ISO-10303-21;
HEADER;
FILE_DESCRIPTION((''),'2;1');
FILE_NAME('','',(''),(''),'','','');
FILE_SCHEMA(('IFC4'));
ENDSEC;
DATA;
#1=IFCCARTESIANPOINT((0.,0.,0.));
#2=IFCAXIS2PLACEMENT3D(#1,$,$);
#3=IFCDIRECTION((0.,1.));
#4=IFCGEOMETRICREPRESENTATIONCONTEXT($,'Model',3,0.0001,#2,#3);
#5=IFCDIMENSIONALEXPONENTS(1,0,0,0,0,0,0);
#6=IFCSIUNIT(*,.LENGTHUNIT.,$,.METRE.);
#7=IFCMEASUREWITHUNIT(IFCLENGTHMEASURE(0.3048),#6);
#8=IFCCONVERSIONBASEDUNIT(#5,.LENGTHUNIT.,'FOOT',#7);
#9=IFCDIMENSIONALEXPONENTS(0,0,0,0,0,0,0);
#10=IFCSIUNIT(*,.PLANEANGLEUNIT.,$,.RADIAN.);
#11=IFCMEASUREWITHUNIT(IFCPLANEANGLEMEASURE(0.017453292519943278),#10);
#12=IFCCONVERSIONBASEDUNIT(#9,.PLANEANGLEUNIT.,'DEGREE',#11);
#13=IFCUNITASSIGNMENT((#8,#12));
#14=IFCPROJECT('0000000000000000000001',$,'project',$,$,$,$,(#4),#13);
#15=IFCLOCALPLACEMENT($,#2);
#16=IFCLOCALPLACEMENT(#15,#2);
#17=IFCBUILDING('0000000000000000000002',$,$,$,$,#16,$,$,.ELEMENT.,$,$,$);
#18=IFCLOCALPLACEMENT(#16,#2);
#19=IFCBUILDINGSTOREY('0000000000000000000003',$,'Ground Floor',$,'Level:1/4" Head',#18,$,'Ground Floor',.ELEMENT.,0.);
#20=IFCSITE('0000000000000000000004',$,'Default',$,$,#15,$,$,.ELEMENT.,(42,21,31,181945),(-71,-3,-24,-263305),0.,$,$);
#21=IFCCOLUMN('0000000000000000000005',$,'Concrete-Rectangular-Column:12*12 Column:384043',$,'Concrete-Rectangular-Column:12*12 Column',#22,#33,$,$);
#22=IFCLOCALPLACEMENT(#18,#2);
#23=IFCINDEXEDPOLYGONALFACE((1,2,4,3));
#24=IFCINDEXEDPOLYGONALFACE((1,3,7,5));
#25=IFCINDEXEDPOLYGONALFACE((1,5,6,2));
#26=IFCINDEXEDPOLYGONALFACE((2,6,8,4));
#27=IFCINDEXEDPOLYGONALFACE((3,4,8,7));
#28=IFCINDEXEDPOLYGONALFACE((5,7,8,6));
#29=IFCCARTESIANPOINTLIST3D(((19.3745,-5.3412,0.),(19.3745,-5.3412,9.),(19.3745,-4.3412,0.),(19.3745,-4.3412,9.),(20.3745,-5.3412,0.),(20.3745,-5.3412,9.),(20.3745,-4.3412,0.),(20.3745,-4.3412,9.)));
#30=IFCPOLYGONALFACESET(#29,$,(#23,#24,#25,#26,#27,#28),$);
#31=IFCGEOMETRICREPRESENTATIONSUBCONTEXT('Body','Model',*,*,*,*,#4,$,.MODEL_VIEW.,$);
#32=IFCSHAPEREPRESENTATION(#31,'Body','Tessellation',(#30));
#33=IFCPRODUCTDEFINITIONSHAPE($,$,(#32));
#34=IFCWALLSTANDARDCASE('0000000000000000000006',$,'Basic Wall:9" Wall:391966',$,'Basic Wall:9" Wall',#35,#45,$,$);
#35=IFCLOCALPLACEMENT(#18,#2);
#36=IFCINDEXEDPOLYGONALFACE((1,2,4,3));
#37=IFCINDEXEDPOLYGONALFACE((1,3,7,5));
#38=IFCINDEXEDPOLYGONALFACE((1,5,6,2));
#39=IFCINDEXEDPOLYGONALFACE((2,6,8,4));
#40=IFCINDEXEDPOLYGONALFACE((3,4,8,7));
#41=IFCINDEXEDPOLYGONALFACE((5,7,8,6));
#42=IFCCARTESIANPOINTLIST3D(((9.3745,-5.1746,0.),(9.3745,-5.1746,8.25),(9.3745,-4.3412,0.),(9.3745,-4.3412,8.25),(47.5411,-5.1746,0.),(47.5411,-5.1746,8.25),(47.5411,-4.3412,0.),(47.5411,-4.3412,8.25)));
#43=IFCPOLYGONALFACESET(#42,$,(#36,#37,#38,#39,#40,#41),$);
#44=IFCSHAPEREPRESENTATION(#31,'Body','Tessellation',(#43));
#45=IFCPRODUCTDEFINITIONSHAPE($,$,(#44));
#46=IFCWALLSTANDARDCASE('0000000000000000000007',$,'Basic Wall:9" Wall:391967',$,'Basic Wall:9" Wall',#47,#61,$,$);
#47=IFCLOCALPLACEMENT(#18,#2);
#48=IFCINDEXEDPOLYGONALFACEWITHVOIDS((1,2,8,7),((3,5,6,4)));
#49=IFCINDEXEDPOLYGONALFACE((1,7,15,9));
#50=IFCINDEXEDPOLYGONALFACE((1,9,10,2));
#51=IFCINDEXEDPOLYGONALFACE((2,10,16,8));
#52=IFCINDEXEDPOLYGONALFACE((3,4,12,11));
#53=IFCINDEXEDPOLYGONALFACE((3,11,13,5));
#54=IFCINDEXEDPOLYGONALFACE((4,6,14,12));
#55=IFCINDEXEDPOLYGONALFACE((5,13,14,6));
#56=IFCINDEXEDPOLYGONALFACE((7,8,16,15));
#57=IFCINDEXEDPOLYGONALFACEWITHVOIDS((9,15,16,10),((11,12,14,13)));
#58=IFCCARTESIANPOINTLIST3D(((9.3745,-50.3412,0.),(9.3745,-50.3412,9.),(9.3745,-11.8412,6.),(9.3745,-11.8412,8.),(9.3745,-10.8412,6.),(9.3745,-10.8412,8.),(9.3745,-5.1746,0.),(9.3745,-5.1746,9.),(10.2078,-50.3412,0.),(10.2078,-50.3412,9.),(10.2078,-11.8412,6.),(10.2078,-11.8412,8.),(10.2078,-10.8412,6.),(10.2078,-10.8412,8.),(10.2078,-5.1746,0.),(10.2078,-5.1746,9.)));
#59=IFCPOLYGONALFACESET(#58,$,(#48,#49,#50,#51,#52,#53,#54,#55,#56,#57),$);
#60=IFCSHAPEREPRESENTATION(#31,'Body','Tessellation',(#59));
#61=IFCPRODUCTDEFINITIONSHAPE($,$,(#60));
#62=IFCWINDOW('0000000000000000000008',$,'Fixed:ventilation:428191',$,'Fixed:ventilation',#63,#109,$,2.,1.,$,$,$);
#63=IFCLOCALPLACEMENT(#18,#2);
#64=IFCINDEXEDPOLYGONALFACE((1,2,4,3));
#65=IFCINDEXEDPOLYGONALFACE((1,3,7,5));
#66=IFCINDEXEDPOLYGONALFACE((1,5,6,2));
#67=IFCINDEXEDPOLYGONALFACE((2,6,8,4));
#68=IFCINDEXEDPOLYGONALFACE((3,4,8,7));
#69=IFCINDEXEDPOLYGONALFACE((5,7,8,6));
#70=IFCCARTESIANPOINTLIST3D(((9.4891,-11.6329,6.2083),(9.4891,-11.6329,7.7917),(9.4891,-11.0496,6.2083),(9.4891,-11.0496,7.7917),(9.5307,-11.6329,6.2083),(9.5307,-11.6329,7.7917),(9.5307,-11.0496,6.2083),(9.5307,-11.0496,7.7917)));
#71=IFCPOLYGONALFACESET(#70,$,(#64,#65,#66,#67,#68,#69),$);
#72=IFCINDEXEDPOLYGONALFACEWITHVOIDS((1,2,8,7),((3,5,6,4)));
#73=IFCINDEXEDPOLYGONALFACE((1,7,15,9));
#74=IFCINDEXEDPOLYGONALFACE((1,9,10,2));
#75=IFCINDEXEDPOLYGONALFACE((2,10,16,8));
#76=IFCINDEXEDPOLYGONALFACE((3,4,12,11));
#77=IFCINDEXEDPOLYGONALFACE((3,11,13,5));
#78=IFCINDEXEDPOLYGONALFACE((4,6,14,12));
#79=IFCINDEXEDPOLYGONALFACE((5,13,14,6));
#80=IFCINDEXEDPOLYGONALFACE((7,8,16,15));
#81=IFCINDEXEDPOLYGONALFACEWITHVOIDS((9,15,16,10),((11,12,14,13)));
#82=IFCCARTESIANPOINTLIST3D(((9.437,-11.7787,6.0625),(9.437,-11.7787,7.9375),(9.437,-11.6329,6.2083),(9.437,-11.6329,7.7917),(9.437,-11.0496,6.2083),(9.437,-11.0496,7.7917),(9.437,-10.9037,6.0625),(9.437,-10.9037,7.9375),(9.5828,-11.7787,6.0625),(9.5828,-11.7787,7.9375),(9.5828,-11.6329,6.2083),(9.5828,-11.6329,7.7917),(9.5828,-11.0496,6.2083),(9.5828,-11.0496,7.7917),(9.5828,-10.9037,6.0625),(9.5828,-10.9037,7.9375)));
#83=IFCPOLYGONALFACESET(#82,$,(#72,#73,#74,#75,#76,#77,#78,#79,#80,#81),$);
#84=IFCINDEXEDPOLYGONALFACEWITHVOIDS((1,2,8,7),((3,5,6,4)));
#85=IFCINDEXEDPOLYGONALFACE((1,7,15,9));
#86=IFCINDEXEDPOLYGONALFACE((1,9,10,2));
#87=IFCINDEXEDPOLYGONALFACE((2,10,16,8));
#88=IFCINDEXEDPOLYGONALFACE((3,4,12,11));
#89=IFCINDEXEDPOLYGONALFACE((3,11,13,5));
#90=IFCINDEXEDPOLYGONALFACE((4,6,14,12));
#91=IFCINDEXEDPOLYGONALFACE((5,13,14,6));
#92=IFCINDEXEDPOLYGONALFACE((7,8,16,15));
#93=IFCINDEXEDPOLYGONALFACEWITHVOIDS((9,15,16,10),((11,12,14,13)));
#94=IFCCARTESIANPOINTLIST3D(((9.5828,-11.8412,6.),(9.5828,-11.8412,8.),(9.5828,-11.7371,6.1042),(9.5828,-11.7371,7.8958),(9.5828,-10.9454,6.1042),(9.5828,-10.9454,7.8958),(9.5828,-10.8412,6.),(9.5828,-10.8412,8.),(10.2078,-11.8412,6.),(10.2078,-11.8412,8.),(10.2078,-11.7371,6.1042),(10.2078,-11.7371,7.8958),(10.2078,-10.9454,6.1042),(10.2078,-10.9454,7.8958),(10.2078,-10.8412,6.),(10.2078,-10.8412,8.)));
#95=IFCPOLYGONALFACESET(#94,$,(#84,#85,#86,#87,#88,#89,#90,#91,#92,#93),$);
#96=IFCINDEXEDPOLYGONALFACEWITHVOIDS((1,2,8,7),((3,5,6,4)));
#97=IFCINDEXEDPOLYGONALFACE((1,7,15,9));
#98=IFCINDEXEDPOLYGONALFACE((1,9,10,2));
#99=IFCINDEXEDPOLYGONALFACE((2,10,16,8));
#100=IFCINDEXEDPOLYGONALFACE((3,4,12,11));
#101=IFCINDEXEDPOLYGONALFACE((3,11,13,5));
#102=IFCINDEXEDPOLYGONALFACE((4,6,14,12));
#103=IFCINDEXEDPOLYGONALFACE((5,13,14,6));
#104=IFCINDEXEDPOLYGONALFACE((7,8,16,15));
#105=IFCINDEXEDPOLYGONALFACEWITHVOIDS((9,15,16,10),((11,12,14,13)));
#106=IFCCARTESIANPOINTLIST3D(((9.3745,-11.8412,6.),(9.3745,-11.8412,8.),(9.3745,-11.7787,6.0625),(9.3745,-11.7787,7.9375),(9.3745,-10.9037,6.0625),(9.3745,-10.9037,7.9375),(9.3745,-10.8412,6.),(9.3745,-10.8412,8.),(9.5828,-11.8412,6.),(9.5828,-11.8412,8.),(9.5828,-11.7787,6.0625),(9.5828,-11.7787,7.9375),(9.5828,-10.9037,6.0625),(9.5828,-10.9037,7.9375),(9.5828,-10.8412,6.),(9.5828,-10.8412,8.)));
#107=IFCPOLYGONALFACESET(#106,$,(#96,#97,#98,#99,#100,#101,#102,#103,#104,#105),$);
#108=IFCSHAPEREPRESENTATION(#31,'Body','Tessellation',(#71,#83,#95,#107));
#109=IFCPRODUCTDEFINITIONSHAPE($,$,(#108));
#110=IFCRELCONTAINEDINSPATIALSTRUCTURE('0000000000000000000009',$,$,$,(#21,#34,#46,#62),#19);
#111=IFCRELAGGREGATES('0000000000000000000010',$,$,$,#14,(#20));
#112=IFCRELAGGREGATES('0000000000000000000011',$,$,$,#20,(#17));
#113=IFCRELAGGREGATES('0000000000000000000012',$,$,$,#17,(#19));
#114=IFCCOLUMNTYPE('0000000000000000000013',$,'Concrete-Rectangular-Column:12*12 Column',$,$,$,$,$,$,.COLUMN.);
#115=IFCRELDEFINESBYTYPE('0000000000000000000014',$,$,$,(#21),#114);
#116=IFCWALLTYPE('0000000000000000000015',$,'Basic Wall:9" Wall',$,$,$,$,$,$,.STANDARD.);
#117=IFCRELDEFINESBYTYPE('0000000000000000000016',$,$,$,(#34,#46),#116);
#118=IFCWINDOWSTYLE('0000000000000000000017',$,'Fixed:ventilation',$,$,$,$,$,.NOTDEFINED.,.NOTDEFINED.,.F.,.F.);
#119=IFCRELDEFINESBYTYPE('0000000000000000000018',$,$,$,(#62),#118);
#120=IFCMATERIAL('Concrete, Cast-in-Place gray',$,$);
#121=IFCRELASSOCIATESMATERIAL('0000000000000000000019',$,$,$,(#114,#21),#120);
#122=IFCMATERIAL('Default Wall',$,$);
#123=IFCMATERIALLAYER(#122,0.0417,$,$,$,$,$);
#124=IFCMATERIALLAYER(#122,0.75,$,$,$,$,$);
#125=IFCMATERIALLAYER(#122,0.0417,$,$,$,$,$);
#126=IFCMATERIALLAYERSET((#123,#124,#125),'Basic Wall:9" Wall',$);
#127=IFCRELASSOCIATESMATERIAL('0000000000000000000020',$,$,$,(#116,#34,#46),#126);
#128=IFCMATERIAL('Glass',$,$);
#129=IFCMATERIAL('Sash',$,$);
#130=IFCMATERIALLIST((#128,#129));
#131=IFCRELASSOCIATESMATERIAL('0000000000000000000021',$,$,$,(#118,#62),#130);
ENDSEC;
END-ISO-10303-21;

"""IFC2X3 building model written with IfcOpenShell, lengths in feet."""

from ifc_helpers import new_model, entity, si_unit, converted_unit, direction, frame, frame_2d, origin, origin_2d_with_axis, place, context, subcontext, project, spatial, polyline, rectangle, outline, extrude, clip, bounded_halfspace, source, transform, mapped, material, material_list, layer, layer_set, layer_usage, type_object, type_shapes, element, fill, save


model = new_model("IFC2X3")

# Units and contexts
model_context = context("Model", 3, precision=0.0001, world=origin(), true_north=direction((0.0, 1.0)))
body_context = subcontext(model_context, "Body", "Model", "MODEL_VIEW")
ifc_project = project(units=[converted_unit("LENGTHUNIT", "FOOT", entity("IfcLengthMeasure", 0.3048), si_unit("LENGTHUNIT", "METRE"), dimensions=[1, 0, 0, 0, 0, 0, 0]), converted_unit("PLANEANGLEUNIT", "DEGREE", entity("IfcPlaneAngleMeasure", 0.017453292519943278), si_unit("PLANEANGLEUNIT", "RADIAN"), dimensions=[0, 0, 0, 0, 0, 0, 0])], contexts=[model_context])

# Site, building, storey
site_placement = place(None, origin())
site = spatial("IfcSite", under=ifc_project, at=site_placement, Name="Default", CompositionType="ELEMENT", RefLatitude=(42, 21, 31, 181945), RefLongitude=(-71, -3, -24, -263305), RefElevation=0.0)
building_placement = place(site_placement, origin())
building = spatial("IfcBuilding", under=site, at=building_placement, CompositionType="ELEMENT")
storey_placement = place(building_placement, origin())
storey = spatial("IfcBuildingStorey", under=building, at=storey_placement, Name="Ground Floor", ObjectType="Level:1/4\" Head", LongName="Ground Floor", CompositionType="ELEMENT", Elevation=0.0)

# Column
ifc_material_1 = material(Name="Concrete, Cast-in-Place gray")
column_type = type_object("IfcColumnType", Name="Concrete-Rectangular-Column:12*12 Column", PredefinedType="COLUMN", material=ifc_material_1)
shared_shape_1 = source(origin(), body_context, "Body", "SweptSolid", [
    extrude(rectangle(XDim=1.0, YDim=1.0, at=frame_2d((0.0, 0.0), x_axis=(1.0, 0.0))), frame((19.8745, -4.8412, 0.0), z_axis=(0.0, 0.0, 1.0), x_axis=(-1.0, 0.0, 0.0)), (0.0, 0.0, 1.0), 9.0),
])
type_shapes(column_type, [shared_shape_1])
column_placement = place(storey_placement, origin())
element("IfcColumn", 1, at=column_placement, inside=storey, type_object=column_type, material=ifc_material_1, Name="Concrete-Rectangular-Column:12*12 Column:384043", ObjectType="Concrete-Rectangular-Column:12*12 Column", context=body_context, shape_type="MappedRepresentation", body=[
    mapped(shared_shape_1, transform((0.0, 0.0, 0.0), scale=1.0)),
])

# Wall
ifc_material_2 = material(Name="Default Wall")
ifc_layer_1 = layer(ifc_material_2, 0.0417)
ifc_layer_2 = layer(ifc_material_2, 0.75)
ifc_layer_3 = layer(ifc_material_2, 0.0417)
ifc_layer_set_1 = layer_set([ifc_layer_1, ifc_layer_2, ifc_layer_3], Name="Basic Wall:9\" Wall")
ifc_layer_usage_1 = layer_usage(ifc_layer_set_1, "AXIS2", "NEGATIVE", 0.4167)
wall_type_1 = type_object("IfcWallType", Name="Basic Wall:9\" Wall", PredefinedType="STANDARD", material=ifc_layer_set_1)
wall_1_placement = place(storey_placement, frame((9.3745, -4.7579, 0.0)))
element("IfcWallStandardCase", 2, at=wall_1_placement, inside=storey, type_object=wall_type_1, material=ifc_layer_usage_1, Name="Basic Wall:9\" Wall:391966", ObjectType="Basic Wall:9\" Wall", context=body_context, shape_type="SweptSolid", body=[
    extrude(rectangle(XDim=38.1667, YDim=0.8333, at=frame_2d((19.0833, 0.0), x_axis=(-1.0, 0.0))), origin(), (0.0, 0.0, 1.0), 8.25),
])

# Wall, opening, window
wall_2_placement = place(storey_placement, frame((9.7911, -50.3412, 0.0), z_axis=(0.0, 0.0, 1.0), x_axis=(0.0, 1.0, 0.0)))
wall_2 = element("IfcWallStandardCase", 3, at=wall_2_placement, inside=storey, type_object=wall_type_1, material=ifc_layer_usage_1, Name="Basic Wall:9\" Wall:391967", ObjectType="Basic Wall:9\" Wall", context=body_context, shape_type="Clipping", body=[
    clip(extrude(rectangle(XDim=45.1667, YDim=0.8333, at=frame_2d((22.5833, 0.0), x_axis=(-1.0, 0.0))), origin(), (0.0, 0.0, 1.0), 9.0), bounded_halfspace(frame((0.0, -0.4167, 9.0), z_axis=(0.0, 0.0, -1.0), x_axis=(-1.0, 0.0, 0.0)), True, frame((0.0, -0.4167, 9.0)), polyline([(0.0, 0.0), (0.8333, 0.0), (45.1667, 0.0), (45.1667, 0.8333), (0.0, 0.8333), (0.0, 0.0)]))),
])
opening_1_placement = place(wall_2_placement, frame((38.5, -0.4167, 6.0)))
opening_1 = element("IfcOpeningElement", 4, at=opening_1_placement, cuts=wall_2, ObjectType="Opening", context=body_context, shape_type="SweptSolid", body=[
    extrude(rectangle(XDim=2.0, YDim=1.0, at=frame_2d((1.0, 0.5), x_axis=(-1.0, 0.0))), frame((0.0, 0.0, 0.0), z_axis=(0.0, 1.0, 0.0), x_axis=(0.0, 0.0, 1.0)), (0.0, 0.0, 1.0), 0.8333),
])
ifc_material_3 = material(Name="Glass")
ifc_material_4 = material(Name="Sash")
ifc_material_list_1 = material_list([ifc_material_3, ifc_material_4])
window_style_1 = type_object("IfcWindowStyle", Name="Fixed:ventilation", ConstructionType="NOTDEFINED", OperationType="NOTDEFINED", ParameterTakesPrecedence=False, Sizeable=False, material=ifc_material_list_1)
shared_shape_2 = source(origin(), body_context, "Body", "SweptSolid", [
    extrude(rectangle(XDim=0.0417, YDim=0.5833, at=origin_2d_with_axis()), frame((0.5, 0.6979, 0.2083), z_axis=(0.0, 0.0, 1.0), x_axis=(0.0, 1.0, 0.0)), (0.0, 0.0, 1.0), 1.5833),
    extrude(outline(polyline([(-0.4375, -0.9375), (0.4375, -0.9375), (0.4375, 0.9375), (-0.4375, 0.9375), (-0.4375, -0.9375)]), holes=[polyline([(-0.2917, -0.7917), (-0.2917, 0.7917), (0.2917, 0.7917), (0.2917, -0.7917), (-0.2917, -0.7917)])]), frame((0.5, 0.625, 1.0), z_axis=(0.0, 1.0, 0.0), x_axis=(1.0, 0.0, 0.0)), (0.0, 0.0, 1.0), 0.1458),
    extrude(outline(polyline([(-0.5, -1.0), (0.5, -1.0), (0.5, 1.0), (-0.5, 1.0), (-0.5, -1.0)]), holes=[polyline([(-0.3958, -0.8958), (-0.3958, 0.8958), (0.3958, 0.8958), (0.3958, -0.8958), (-0.3958, -0.8958)])]), frame((0.5, 0.0, 1.0), z_axis=(0.0, 1.0, 0.0), x_axis=(1.0, 0.0, 0.0)), (0.0, 0.0, 1.0), 0.625),
    extrude(outline(polyline([(-1.0, -0.5), (1.0, -0.5), (1.0, 0.5), (-1.0, 0.5), (-1.0, -0.5)]), holes=[polyline([(-0.9375, -0.4375), (-0.9375, 0.4375), (0.9375, 0.4375), (0.9375, -0.4375), (-0.9375, -0.4375)])]), frame((0.5, 0.625, 1.0), z_axis=(0.0, 1.0, 0.0), x_axis=(0.0, 0.0, -1.0)), (0.0, 0.0, 1.0), 0.2083),
])
type_shapes(window_style_1, [shared_shape_2])
window_1_placement = place(opening_1_placement, origin())
window_1 = element("IfcWindow", 5, at=window_1_placement, inside=storey, type_object=window_style_1, material=ifc_material_list_1, Name="Fixed:ventilation:428191", ObjectType="Fixed:ventilation", OverallHeight=2.0, OverallWidth=1.0, context=body_context, shape_type="MappedRepresentation", body=[
    mapped(shared_shape_2, transform((0.0, 0.0, 0.0), scale=1.0)),
])
fill(opening_1, window_1)

save(model, "model.ifc")
